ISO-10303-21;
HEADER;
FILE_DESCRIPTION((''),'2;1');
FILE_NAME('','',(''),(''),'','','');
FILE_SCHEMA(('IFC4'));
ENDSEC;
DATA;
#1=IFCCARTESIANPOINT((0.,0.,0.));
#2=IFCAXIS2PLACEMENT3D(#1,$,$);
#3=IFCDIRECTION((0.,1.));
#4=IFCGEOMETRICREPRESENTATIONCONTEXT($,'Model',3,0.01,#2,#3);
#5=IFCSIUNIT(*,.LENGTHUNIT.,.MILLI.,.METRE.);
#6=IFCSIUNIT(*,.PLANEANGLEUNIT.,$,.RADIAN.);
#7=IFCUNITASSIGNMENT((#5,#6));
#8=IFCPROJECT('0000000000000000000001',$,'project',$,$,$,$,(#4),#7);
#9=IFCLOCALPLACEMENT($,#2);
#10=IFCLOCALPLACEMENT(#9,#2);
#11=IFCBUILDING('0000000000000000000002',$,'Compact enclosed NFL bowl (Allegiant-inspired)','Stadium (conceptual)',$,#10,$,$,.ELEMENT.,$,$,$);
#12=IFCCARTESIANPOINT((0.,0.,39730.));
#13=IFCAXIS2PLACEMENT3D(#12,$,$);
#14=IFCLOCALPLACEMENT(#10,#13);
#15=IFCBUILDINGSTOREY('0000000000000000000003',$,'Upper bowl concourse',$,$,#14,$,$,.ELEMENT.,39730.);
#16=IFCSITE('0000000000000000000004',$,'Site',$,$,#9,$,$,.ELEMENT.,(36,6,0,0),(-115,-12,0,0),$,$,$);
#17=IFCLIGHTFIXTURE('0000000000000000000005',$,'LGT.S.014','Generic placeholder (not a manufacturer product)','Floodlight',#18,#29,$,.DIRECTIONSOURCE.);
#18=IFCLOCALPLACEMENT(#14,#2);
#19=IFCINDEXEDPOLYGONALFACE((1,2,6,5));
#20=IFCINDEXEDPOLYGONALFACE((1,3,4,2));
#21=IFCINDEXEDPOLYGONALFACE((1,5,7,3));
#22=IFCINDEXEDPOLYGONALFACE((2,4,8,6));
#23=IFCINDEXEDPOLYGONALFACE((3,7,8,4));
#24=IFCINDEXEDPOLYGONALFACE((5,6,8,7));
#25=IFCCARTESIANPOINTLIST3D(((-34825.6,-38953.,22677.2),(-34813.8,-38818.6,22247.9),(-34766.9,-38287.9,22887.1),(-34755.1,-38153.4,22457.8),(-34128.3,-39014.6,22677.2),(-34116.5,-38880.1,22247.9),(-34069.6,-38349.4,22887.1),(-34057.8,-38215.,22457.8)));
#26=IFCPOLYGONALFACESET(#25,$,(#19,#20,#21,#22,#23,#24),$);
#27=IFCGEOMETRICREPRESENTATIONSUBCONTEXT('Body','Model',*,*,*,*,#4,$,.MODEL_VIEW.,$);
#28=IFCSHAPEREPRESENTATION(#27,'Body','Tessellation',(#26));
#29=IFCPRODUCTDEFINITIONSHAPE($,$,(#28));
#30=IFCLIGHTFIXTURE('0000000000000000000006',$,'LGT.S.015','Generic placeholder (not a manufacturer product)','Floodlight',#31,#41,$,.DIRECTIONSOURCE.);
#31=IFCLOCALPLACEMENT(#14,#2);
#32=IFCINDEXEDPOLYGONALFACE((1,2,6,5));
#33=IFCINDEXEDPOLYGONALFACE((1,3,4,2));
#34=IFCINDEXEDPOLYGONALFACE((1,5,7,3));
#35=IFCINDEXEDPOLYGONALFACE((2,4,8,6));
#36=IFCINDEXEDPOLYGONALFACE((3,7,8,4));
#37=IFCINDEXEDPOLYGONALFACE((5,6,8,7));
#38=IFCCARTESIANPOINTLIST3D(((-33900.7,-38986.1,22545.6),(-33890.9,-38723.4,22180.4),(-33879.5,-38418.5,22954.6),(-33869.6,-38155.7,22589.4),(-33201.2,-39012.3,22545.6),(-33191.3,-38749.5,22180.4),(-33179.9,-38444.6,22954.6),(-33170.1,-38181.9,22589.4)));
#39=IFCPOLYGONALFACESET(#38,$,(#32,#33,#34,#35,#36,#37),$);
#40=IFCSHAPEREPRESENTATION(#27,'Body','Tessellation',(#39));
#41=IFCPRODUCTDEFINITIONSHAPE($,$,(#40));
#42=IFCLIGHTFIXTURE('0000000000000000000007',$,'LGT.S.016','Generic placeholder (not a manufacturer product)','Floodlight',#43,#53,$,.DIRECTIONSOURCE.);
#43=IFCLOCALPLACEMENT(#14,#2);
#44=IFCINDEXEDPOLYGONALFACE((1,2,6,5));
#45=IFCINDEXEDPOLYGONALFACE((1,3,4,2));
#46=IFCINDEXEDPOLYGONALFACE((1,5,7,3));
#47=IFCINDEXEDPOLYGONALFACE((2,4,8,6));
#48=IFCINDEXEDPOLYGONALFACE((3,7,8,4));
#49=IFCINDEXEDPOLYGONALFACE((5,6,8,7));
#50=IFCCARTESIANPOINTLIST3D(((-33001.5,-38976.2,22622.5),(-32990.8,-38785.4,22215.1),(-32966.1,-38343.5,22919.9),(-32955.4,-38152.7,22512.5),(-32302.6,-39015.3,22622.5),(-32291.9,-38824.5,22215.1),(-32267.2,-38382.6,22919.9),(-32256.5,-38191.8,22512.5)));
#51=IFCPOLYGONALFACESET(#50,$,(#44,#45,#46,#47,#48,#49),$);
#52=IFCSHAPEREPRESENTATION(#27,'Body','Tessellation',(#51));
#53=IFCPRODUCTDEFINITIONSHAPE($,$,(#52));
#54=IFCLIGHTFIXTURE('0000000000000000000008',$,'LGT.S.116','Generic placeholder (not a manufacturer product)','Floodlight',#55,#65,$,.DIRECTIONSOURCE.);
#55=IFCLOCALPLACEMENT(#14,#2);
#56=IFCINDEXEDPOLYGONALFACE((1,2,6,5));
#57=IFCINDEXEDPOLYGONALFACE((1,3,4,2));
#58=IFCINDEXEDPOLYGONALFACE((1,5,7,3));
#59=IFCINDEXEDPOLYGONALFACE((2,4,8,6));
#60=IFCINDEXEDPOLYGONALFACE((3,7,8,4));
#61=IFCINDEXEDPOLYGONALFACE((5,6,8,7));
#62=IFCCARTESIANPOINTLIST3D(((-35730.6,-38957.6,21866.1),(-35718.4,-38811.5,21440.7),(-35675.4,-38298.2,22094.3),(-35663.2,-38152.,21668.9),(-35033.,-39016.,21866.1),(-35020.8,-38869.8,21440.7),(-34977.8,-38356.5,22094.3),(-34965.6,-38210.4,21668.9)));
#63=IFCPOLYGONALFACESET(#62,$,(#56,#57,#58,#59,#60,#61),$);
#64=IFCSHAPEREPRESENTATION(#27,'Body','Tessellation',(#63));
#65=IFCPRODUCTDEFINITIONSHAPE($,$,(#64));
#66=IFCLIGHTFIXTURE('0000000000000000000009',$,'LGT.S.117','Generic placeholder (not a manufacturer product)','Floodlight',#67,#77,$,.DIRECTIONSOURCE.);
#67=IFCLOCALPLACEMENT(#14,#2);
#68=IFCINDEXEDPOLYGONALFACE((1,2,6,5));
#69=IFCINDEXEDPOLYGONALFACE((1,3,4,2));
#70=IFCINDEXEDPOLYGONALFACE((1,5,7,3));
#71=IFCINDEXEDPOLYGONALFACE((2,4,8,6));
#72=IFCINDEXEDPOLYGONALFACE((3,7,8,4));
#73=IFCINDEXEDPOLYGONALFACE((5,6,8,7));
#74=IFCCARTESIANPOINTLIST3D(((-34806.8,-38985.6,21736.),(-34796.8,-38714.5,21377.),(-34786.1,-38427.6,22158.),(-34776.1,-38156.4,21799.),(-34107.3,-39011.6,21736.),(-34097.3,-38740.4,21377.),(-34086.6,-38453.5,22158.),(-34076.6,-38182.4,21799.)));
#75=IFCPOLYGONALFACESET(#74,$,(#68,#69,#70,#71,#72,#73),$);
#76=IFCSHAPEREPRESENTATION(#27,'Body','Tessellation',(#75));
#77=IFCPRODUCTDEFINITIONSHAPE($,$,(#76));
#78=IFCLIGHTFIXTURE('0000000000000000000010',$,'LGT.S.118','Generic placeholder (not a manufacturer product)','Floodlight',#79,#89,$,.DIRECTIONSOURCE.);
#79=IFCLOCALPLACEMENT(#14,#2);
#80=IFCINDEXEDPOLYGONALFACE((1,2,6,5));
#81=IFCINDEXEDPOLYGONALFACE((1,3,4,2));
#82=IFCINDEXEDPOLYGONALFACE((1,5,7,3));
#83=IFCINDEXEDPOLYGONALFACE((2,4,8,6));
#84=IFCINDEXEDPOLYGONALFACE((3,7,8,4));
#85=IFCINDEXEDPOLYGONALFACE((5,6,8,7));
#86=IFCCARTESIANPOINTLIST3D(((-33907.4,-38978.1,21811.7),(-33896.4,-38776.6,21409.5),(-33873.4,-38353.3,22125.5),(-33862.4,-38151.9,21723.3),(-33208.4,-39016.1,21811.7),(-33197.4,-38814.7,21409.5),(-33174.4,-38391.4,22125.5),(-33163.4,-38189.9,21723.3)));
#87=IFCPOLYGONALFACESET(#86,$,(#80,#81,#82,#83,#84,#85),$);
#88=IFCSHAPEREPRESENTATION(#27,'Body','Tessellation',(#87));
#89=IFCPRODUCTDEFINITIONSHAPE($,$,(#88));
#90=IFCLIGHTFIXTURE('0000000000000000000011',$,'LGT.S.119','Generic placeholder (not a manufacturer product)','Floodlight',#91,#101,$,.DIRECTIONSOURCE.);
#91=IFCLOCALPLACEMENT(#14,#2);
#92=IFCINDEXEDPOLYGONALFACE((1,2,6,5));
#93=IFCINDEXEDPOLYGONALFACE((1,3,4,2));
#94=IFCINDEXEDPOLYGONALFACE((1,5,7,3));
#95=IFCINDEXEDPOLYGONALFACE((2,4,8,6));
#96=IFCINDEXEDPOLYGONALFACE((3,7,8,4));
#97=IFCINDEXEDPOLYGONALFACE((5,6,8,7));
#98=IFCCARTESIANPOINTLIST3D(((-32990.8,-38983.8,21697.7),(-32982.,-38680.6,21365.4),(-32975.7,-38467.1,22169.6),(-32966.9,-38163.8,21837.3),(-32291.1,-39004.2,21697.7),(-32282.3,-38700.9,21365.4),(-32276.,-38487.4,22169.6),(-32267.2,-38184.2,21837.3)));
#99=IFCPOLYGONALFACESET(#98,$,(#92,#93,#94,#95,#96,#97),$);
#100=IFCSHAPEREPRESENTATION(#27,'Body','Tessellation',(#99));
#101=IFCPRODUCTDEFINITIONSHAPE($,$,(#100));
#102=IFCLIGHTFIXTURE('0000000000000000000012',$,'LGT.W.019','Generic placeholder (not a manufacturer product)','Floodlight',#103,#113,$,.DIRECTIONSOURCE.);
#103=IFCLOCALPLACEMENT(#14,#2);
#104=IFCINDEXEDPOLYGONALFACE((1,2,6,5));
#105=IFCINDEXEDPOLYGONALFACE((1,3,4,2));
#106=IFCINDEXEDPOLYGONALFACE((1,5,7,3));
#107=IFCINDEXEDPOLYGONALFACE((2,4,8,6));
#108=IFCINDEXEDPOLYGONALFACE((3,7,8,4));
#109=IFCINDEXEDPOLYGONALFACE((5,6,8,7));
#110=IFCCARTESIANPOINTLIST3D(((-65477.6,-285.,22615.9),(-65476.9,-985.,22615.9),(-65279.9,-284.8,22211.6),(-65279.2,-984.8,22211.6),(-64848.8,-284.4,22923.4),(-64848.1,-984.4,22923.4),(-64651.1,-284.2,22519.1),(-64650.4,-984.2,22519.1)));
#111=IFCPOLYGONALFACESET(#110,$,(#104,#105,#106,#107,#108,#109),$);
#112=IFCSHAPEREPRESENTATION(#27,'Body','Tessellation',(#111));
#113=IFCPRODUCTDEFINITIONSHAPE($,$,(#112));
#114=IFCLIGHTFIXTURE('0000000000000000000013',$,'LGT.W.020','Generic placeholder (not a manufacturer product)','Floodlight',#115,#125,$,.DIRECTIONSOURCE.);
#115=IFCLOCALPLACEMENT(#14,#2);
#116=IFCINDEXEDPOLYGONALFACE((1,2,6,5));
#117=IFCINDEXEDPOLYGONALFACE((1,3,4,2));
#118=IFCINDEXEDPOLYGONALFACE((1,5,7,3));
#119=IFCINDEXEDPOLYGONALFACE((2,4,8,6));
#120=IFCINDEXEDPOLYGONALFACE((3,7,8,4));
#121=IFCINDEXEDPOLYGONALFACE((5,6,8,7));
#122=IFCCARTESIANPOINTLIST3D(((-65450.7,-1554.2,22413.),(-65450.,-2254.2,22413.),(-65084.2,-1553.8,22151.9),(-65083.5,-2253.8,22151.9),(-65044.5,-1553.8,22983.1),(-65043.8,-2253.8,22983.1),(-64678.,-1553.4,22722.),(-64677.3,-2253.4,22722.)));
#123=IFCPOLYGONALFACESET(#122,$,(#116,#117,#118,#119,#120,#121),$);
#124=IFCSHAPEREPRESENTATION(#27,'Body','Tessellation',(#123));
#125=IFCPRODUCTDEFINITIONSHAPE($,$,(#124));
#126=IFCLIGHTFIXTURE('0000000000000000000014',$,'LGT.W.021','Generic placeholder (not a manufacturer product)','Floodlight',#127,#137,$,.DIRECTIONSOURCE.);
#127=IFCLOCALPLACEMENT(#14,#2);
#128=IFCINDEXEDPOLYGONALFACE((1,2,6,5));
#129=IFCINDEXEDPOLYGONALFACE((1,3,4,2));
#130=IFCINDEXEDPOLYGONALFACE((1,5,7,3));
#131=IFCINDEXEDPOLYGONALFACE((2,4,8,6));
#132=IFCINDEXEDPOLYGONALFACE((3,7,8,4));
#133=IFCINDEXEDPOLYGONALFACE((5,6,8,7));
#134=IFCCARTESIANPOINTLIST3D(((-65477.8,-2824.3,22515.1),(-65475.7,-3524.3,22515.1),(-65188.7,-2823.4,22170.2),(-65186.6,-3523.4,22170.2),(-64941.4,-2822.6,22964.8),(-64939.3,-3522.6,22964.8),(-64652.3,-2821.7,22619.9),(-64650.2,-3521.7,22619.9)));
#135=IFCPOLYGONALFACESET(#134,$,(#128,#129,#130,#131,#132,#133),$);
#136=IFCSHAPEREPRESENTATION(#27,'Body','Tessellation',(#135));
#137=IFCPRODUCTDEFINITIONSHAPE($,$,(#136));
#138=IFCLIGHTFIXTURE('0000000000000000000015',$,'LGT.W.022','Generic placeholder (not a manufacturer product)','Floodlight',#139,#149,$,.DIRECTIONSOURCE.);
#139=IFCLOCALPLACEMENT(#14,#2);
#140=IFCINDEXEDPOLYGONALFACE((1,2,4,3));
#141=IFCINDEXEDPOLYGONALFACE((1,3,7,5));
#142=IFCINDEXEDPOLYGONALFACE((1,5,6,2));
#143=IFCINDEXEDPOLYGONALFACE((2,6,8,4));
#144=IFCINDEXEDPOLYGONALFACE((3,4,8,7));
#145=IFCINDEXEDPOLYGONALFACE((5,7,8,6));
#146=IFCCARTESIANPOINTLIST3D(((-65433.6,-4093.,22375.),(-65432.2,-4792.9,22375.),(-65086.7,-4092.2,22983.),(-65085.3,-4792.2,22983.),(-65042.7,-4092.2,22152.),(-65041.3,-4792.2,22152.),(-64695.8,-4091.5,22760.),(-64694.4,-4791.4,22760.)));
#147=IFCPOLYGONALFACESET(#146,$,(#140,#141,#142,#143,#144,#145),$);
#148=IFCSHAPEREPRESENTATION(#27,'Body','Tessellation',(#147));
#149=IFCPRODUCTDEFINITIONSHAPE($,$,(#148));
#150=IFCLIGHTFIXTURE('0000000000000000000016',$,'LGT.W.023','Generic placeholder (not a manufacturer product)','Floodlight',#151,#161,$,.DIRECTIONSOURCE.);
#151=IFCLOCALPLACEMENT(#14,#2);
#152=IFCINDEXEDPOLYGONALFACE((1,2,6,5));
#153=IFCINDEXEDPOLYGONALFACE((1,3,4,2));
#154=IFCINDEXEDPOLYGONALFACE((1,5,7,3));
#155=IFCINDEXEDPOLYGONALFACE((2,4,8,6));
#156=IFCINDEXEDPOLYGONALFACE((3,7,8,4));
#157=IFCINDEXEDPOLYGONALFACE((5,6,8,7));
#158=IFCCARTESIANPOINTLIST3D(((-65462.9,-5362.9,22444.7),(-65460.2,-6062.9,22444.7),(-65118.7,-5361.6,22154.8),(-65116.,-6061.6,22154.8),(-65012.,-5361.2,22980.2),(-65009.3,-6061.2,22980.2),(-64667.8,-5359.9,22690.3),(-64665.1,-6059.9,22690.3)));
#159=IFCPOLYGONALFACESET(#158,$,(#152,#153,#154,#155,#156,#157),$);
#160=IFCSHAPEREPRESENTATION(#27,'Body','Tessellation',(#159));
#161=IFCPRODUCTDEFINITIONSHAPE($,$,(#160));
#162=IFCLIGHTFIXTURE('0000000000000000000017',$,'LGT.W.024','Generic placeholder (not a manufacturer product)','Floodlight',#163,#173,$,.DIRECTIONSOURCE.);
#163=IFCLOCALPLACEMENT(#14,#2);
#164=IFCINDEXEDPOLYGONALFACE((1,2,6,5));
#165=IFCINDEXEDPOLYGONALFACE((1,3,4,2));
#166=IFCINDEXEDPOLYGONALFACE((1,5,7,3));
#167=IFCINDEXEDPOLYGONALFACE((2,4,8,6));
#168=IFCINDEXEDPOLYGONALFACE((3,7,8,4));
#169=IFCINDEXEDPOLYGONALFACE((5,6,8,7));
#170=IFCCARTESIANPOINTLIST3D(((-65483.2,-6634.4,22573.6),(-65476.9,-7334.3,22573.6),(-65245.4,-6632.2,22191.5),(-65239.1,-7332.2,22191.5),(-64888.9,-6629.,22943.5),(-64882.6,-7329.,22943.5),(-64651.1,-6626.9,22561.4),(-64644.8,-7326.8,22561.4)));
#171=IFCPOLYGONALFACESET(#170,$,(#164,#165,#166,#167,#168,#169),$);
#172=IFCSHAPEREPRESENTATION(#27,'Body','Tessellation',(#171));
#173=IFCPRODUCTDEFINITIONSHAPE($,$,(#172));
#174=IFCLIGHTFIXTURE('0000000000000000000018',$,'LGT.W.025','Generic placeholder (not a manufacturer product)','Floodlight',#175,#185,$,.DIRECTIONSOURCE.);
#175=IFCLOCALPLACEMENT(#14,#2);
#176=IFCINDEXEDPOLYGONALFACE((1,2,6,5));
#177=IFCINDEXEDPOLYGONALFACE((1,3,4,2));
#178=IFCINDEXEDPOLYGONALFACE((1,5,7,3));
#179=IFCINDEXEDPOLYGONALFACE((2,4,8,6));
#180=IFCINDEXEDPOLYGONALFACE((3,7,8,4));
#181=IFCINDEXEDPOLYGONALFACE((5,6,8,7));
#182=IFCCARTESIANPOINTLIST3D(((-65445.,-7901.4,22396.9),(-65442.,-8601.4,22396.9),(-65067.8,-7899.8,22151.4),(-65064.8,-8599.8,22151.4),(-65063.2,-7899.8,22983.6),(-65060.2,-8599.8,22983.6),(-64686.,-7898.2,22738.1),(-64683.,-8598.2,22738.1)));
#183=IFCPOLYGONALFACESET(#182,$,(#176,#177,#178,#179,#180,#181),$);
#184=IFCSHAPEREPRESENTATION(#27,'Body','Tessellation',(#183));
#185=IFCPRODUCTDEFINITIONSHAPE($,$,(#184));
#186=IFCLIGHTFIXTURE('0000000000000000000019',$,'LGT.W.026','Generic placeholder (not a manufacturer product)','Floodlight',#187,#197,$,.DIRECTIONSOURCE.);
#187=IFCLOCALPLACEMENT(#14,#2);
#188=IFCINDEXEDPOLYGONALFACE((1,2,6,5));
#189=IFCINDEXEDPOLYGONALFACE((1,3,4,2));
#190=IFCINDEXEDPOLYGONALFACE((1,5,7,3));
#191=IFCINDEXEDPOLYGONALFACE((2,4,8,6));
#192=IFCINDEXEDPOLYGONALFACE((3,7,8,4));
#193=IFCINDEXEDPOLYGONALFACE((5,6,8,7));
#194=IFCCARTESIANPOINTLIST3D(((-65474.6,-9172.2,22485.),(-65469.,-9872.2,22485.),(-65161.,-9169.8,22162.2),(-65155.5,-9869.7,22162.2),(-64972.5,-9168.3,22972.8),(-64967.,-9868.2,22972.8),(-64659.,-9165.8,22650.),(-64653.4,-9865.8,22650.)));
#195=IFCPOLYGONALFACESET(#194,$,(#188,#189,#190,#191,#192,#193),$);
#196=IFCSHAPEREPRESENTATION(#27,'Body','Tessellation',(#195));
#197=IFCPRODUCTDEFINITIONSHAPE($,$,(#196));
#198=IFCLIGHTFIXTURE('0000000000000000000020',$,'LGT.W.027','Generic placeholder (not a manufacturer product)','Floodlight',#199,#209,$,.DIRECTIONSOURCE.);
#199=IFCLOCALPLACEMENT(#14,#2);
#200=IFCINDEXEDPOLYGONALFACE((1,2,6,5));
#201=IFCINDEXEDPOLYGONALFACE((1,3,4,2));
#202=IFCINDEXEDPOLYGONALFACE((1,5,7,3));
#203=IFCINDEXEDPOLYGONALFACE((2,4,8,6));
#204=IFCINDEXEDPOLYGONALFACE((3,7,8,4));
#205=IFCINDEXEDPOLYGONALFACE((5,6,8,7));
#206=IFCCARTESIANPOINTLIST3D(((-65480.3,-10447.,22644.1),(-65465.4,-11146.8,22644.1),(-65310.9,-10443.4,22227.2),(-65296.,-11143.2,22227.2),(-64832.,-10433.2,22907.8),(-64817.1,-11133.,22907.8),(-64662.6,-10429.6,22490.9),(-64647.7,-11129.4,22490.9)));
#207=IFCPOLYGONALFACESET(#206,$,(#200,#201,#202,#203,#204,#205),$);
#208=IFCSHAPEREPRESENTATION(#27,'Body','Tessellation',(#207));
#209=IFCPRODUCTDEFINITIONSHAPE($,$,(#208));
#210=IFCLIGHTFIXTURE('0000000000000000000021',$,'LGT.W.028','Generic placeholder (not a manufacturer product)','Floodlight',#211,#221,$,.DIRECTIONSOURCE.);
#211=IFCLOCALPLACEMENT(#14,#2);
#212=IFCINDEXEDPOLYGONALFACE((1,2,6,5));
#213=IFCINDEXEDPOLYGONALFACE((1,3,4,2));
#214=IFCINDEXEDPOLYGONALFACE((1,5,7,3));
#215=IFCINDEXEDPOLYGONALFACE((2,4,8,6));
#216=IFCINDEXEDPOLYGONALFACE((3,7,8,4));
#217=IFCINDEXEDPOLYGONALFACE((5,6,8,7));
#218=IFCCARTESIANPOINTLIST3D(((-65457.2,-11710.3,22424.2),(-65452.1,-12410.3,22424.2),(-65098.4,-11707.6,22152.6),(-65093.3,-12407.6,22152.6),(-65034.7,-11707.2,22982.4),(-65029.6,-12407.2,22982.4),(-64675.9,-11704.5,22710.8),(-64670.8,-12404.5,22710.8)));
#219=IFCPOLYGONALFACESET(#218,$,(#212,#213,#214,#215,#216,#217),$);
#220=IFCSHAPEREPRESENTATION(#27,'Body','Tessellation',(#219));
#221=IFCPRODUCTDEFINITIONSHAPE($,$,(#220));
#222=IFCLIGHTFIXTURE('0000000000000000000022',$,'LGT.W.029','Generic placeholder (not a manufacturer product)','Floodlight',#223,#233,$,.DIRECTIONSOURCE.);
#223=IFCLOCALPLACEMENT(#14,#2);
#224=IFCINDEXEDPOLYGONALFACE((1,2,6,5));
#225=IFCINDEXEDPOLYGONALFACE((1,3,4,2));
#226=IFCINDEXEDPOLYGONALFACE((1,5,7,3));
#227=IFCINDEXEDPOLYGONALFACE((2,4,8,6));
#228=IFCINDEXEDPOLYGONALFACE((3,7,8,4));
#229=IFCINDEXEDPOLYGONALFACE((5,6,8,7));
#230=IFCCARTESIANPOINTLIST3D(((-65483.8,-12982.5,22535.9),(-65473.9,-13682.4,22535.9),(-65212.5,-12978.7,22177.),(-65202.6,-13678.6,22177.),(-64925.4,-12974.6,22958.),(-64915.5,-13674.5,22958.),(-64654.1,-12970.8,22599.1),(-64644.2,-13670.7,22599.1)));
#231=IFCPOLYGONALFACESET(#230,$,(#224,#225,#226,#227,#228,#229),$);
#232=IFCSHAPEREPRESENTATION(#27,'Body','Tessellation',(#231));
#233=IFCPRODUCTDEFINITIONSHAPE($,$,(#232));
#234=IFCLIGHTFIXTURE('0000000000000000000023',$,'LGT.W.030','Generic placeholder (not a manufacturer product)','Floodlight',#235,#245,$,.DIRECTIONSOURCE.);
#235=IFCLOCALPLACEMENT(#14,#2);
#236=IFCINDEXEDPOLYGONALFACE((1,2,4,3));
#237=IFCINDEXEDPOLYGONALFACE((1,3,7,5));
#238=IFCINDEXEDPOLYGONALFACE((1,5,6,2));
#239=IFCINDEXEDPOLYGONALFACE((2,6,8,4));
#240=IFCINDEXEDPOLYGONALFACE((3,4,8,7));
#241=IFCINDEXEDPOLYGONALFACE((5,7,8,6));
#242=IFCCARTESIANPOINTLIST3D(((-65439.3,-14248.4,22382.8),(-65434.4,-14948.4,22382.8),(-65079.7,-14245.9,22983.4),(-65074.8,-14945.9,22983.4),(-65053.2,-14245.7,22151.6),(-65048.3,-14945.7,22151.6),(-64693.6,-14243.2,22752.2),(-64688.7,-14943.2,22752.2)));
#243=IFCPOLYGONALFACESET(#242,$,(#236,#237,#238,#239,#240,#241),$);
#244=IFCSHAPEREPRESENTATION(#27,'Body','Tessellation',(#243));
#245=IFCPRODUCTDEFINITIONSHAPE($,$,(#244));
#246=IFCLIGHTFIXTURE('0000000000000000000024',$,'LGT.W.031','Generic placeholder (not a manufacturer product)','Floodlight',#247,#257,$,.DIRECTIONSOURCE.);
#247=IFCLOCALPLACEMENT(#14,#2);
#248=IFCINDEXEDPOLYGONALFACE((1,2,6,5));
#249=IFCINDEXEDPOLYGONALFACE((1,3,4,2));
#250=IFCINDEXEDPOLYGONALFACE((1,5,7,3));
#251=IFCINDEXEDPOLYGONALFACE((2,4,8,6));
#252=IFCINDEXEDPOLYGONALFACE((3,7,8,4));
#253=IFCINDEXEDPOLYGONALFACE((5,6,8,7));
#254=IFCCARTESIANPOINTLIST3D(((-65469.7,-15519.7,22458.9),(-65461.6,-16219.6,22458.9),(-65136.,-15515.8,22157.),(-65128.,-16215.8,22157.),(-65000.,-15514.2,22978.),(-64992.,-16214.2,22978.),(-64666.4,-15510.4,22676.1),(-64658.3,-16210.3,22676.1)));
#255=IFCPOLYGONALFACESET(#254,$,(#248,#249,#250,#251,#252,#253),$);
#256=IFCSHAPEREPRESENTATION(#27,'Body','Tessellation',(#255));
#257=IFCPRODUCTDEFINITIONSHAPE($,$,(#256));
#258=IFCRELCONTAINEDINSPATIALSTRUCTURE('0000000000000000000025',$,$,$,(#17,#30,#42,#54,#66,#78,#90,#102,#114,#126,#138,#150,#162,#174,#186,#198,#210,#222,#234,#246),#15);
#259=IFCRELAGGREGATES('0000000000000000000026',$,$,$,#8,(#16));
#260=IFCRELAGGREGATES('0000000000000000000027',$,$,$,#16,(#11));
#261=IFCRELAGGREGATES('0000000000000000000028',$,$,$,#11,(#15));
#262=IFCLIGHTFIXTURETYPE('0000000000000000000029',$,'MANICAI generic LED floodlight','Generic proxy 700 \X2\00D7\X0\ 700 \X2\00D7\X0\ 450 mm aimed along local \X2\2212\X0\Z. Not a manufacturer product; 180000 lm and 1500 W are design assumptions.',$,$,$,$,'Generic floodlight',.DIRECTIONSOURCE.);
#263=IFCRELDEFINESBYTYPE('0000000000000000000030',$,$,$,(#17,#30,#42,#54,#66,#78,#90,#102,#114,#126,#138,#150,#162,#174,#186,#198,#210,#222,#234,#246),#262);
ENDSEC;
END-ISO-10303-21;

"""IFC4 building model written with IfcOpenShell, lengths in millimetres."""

from ifc_helpers import new_model, si_unit, direction, frame, origin, place, context, subcontext, project, spatial, rectangle, extrude, source, transform, mapped, type_object, type_shapes, element, save


model = new_model("IFC4")

# Units and contexts
model_context = context("Model", 3, precision=0.01, world=origin(), true_north=direction((0.0, 1.0)))
body_context = subcontext(model_context, "Body", "Model", "MODEL_VIEW")
ifc_project = project(units=[si_unit("LENGTHUNIT", "METRE", prefix="MILLI"), si_unit("PLANEANGLEUNIT", "RADIAN")], contexts=[model_context])

# Site, building, storey
site_placement = place(None, origin())
site = spatial("IfcSite", under=ifc_project, at=site_placement, Name="Site", CompositionType="ELEMENT", RefLatitude=(36, 6, 0, 0), RefLongitude=(-115, -12, 0, 0))
building_placement = place(site_placement, origin())
building = spatial("IfcBuilding", under=site, at=building_placement, Name="Compact enclosed NFL bowl (Allegiant-inspired)", Description="Stadium (conceptual)", CompositionType="ELEMENT")
storey_placement = place(building_placement, frame((0.0, 0.0, 39730.0)))
storey = spatial("IfcBuildingStorey", under=building, at=storey_placement, Name="Upper bowl concourse", CompositionType="ELEMENT", Elevation=39730.0)

# Light fixtures
light_fixture_type = type_object("IfcLightFixtureType", Name="MANICAI generic LED floodlight", Description="Generic proxy 700 × 700 × 450 mm aimed along local −Z. Not a manufacturer product; 180000 lm and 1500 W are design assumptions.", ElementType="Generic floodlight", PredefinedType="DIRECTIONSOURCE")
shared_shape = source(origin(), body_context, "Body", "SweptSolid", [
    extrude(rectangle(XDim=700.0, YDim=700.0), frame((0.0, 0.0, -225.0)), (0.0, 0.0, 1.0), 450.0),
])
type_shapes(light_fixture_type, [shared_shape])
for number, where, z_axis, x_axis, name in (
    (1, (-34441.7, -38584.0, 22567.5), (-0.02637, -0.29879, 0.953954), (0.996128, -0.087914, 0.0), "LGT.S.014"),
    (2, (-33535.4, -38584.0, 22567.5), (-0.021842, -0.583959, 0.811489), (0.999301, -0.037377, 0.0), "LGT.S.015"),
    (3, (-32629.0, -38584.0, 22567.5), (-0.023708, -0.424088, 0.905311), (0.998441, -0.055817, 0.0), "LGT.S.016"),
    (4, (-35348.1, -38584.0, 21767.5), (-0.02717, -0.324813, 0.945388), (0.99652, -0.083357, 0.0), "LGT.S.116"),
    (5, (-34441.7, -38584.0, 21767.5), (-0.02234, -0.602536, 0.797779), (0.999313, -0.037051, 0.0), "LGT.S.117"),
    (6, (-33535.4, -38584.0, 21767.5), (-0.024372, -0.447673, 0.893865), (0.998521, -0.054361, 0.0), "LGT.S.118"),
    (7, (-32629.0, -38584.0, 21767.5), (-0.019592, -0.673928, 0.738537), (0.999578, -0.02906, 0.0), "LGT.S.119"),
    (8, (-65064.0, -634.6, 22567.5), (-0.439296, -0.000458, 0.898342), (0.001042, -0.999999, 0.0), "LGT.W.019"),
    (9, (-65064.0, -1903.8, 22567.5), (-0.814402, -0.000887, 0.580301), (0.001089, -0.999999, 0.0), "LGT.W.020"),
    (10, (-65064.0, -3173.0, 22567.5), (-0.642417, -0.001952, 0.766353), (0.003038, -0.999995, 0.0), "LGT.W.021"),
    (11, (-65064.0, -4442.2, 22567.5), (-0.868569, -0.001767, 0.495565), (0.002034, -0.999998, 0.0), "LGT.W.022"),
    (12, (-65064.0, -5711.4, 22567.5), (-0.764921, -0.002953, 0.644117), (0.00386, -0.999993, 0.0), "LGT.W.023"),
    (13, (-65064.0, -6980.6, 22567.5), (-0.528415, -0.004756, 0.848973), (0.009001, -0.999959, 0.0), "LGT.W.024"),
    (14, (-65064.0, -8249.8, 22567.5), (-0.838172, -0.003611, 0.545393), (0.004308, -0.999991, 0.0), "LGT.W.025"),
    (15, (-65064.0, -9519.0, 22567.5), (-0.696871, -0.005479, 0.717175), (0.007862, -0.999969, 0.0), "LGT.W.026"),
    (16, (-65064.0, -10788.2, 22567.5), (-0.376607, -0.008021, 0.926338), (0.021293, -0.999773, 0.0), "LGT.W.027"),
    (17, (-65064.0, -12057.4, 22567.5), (-0.79729, -0.005841, 0.603568), (0.007326, -0.999973, 0.0), "LGT.W.028"),
    (18, (-65064.0, -13326.6, 22567.5), (-0.602949, -0.008533, 0.797734), (0.01415, -0.9999, 0.0), "LGT.W.029"),
    (19, (-65064.0, -14595.8, 22567.5), (-0.857962, -0.006018, 0.513678), (0.007014, -0.999975, 0.0), "LGT.W.030"),
    (20, (-65064.0, -15865.0, 22567.5), (-0.741459, -0.008543, 0.670944), (0.011522, -0.999934, 0.0), "LGT.W.031"),
):
    element("IfcLightFixture", number, at=place(storey_placement, frame(where, z_axis=z_axis, x_axis=x_axis)), inside=storey, type_object=light_fixture_type, Name=name, Description="Generic placeholder (not a manufacturer product)", ObjectType="Floodlight", PredefinedType="DIRECTIONSOURCE", context=body_context, shape_type="MappedRepresentation", body=[
        mapped(shared_shape, transform((0.0, 0.0, 0.0))),
    ])

save(model, "model.ifc")
